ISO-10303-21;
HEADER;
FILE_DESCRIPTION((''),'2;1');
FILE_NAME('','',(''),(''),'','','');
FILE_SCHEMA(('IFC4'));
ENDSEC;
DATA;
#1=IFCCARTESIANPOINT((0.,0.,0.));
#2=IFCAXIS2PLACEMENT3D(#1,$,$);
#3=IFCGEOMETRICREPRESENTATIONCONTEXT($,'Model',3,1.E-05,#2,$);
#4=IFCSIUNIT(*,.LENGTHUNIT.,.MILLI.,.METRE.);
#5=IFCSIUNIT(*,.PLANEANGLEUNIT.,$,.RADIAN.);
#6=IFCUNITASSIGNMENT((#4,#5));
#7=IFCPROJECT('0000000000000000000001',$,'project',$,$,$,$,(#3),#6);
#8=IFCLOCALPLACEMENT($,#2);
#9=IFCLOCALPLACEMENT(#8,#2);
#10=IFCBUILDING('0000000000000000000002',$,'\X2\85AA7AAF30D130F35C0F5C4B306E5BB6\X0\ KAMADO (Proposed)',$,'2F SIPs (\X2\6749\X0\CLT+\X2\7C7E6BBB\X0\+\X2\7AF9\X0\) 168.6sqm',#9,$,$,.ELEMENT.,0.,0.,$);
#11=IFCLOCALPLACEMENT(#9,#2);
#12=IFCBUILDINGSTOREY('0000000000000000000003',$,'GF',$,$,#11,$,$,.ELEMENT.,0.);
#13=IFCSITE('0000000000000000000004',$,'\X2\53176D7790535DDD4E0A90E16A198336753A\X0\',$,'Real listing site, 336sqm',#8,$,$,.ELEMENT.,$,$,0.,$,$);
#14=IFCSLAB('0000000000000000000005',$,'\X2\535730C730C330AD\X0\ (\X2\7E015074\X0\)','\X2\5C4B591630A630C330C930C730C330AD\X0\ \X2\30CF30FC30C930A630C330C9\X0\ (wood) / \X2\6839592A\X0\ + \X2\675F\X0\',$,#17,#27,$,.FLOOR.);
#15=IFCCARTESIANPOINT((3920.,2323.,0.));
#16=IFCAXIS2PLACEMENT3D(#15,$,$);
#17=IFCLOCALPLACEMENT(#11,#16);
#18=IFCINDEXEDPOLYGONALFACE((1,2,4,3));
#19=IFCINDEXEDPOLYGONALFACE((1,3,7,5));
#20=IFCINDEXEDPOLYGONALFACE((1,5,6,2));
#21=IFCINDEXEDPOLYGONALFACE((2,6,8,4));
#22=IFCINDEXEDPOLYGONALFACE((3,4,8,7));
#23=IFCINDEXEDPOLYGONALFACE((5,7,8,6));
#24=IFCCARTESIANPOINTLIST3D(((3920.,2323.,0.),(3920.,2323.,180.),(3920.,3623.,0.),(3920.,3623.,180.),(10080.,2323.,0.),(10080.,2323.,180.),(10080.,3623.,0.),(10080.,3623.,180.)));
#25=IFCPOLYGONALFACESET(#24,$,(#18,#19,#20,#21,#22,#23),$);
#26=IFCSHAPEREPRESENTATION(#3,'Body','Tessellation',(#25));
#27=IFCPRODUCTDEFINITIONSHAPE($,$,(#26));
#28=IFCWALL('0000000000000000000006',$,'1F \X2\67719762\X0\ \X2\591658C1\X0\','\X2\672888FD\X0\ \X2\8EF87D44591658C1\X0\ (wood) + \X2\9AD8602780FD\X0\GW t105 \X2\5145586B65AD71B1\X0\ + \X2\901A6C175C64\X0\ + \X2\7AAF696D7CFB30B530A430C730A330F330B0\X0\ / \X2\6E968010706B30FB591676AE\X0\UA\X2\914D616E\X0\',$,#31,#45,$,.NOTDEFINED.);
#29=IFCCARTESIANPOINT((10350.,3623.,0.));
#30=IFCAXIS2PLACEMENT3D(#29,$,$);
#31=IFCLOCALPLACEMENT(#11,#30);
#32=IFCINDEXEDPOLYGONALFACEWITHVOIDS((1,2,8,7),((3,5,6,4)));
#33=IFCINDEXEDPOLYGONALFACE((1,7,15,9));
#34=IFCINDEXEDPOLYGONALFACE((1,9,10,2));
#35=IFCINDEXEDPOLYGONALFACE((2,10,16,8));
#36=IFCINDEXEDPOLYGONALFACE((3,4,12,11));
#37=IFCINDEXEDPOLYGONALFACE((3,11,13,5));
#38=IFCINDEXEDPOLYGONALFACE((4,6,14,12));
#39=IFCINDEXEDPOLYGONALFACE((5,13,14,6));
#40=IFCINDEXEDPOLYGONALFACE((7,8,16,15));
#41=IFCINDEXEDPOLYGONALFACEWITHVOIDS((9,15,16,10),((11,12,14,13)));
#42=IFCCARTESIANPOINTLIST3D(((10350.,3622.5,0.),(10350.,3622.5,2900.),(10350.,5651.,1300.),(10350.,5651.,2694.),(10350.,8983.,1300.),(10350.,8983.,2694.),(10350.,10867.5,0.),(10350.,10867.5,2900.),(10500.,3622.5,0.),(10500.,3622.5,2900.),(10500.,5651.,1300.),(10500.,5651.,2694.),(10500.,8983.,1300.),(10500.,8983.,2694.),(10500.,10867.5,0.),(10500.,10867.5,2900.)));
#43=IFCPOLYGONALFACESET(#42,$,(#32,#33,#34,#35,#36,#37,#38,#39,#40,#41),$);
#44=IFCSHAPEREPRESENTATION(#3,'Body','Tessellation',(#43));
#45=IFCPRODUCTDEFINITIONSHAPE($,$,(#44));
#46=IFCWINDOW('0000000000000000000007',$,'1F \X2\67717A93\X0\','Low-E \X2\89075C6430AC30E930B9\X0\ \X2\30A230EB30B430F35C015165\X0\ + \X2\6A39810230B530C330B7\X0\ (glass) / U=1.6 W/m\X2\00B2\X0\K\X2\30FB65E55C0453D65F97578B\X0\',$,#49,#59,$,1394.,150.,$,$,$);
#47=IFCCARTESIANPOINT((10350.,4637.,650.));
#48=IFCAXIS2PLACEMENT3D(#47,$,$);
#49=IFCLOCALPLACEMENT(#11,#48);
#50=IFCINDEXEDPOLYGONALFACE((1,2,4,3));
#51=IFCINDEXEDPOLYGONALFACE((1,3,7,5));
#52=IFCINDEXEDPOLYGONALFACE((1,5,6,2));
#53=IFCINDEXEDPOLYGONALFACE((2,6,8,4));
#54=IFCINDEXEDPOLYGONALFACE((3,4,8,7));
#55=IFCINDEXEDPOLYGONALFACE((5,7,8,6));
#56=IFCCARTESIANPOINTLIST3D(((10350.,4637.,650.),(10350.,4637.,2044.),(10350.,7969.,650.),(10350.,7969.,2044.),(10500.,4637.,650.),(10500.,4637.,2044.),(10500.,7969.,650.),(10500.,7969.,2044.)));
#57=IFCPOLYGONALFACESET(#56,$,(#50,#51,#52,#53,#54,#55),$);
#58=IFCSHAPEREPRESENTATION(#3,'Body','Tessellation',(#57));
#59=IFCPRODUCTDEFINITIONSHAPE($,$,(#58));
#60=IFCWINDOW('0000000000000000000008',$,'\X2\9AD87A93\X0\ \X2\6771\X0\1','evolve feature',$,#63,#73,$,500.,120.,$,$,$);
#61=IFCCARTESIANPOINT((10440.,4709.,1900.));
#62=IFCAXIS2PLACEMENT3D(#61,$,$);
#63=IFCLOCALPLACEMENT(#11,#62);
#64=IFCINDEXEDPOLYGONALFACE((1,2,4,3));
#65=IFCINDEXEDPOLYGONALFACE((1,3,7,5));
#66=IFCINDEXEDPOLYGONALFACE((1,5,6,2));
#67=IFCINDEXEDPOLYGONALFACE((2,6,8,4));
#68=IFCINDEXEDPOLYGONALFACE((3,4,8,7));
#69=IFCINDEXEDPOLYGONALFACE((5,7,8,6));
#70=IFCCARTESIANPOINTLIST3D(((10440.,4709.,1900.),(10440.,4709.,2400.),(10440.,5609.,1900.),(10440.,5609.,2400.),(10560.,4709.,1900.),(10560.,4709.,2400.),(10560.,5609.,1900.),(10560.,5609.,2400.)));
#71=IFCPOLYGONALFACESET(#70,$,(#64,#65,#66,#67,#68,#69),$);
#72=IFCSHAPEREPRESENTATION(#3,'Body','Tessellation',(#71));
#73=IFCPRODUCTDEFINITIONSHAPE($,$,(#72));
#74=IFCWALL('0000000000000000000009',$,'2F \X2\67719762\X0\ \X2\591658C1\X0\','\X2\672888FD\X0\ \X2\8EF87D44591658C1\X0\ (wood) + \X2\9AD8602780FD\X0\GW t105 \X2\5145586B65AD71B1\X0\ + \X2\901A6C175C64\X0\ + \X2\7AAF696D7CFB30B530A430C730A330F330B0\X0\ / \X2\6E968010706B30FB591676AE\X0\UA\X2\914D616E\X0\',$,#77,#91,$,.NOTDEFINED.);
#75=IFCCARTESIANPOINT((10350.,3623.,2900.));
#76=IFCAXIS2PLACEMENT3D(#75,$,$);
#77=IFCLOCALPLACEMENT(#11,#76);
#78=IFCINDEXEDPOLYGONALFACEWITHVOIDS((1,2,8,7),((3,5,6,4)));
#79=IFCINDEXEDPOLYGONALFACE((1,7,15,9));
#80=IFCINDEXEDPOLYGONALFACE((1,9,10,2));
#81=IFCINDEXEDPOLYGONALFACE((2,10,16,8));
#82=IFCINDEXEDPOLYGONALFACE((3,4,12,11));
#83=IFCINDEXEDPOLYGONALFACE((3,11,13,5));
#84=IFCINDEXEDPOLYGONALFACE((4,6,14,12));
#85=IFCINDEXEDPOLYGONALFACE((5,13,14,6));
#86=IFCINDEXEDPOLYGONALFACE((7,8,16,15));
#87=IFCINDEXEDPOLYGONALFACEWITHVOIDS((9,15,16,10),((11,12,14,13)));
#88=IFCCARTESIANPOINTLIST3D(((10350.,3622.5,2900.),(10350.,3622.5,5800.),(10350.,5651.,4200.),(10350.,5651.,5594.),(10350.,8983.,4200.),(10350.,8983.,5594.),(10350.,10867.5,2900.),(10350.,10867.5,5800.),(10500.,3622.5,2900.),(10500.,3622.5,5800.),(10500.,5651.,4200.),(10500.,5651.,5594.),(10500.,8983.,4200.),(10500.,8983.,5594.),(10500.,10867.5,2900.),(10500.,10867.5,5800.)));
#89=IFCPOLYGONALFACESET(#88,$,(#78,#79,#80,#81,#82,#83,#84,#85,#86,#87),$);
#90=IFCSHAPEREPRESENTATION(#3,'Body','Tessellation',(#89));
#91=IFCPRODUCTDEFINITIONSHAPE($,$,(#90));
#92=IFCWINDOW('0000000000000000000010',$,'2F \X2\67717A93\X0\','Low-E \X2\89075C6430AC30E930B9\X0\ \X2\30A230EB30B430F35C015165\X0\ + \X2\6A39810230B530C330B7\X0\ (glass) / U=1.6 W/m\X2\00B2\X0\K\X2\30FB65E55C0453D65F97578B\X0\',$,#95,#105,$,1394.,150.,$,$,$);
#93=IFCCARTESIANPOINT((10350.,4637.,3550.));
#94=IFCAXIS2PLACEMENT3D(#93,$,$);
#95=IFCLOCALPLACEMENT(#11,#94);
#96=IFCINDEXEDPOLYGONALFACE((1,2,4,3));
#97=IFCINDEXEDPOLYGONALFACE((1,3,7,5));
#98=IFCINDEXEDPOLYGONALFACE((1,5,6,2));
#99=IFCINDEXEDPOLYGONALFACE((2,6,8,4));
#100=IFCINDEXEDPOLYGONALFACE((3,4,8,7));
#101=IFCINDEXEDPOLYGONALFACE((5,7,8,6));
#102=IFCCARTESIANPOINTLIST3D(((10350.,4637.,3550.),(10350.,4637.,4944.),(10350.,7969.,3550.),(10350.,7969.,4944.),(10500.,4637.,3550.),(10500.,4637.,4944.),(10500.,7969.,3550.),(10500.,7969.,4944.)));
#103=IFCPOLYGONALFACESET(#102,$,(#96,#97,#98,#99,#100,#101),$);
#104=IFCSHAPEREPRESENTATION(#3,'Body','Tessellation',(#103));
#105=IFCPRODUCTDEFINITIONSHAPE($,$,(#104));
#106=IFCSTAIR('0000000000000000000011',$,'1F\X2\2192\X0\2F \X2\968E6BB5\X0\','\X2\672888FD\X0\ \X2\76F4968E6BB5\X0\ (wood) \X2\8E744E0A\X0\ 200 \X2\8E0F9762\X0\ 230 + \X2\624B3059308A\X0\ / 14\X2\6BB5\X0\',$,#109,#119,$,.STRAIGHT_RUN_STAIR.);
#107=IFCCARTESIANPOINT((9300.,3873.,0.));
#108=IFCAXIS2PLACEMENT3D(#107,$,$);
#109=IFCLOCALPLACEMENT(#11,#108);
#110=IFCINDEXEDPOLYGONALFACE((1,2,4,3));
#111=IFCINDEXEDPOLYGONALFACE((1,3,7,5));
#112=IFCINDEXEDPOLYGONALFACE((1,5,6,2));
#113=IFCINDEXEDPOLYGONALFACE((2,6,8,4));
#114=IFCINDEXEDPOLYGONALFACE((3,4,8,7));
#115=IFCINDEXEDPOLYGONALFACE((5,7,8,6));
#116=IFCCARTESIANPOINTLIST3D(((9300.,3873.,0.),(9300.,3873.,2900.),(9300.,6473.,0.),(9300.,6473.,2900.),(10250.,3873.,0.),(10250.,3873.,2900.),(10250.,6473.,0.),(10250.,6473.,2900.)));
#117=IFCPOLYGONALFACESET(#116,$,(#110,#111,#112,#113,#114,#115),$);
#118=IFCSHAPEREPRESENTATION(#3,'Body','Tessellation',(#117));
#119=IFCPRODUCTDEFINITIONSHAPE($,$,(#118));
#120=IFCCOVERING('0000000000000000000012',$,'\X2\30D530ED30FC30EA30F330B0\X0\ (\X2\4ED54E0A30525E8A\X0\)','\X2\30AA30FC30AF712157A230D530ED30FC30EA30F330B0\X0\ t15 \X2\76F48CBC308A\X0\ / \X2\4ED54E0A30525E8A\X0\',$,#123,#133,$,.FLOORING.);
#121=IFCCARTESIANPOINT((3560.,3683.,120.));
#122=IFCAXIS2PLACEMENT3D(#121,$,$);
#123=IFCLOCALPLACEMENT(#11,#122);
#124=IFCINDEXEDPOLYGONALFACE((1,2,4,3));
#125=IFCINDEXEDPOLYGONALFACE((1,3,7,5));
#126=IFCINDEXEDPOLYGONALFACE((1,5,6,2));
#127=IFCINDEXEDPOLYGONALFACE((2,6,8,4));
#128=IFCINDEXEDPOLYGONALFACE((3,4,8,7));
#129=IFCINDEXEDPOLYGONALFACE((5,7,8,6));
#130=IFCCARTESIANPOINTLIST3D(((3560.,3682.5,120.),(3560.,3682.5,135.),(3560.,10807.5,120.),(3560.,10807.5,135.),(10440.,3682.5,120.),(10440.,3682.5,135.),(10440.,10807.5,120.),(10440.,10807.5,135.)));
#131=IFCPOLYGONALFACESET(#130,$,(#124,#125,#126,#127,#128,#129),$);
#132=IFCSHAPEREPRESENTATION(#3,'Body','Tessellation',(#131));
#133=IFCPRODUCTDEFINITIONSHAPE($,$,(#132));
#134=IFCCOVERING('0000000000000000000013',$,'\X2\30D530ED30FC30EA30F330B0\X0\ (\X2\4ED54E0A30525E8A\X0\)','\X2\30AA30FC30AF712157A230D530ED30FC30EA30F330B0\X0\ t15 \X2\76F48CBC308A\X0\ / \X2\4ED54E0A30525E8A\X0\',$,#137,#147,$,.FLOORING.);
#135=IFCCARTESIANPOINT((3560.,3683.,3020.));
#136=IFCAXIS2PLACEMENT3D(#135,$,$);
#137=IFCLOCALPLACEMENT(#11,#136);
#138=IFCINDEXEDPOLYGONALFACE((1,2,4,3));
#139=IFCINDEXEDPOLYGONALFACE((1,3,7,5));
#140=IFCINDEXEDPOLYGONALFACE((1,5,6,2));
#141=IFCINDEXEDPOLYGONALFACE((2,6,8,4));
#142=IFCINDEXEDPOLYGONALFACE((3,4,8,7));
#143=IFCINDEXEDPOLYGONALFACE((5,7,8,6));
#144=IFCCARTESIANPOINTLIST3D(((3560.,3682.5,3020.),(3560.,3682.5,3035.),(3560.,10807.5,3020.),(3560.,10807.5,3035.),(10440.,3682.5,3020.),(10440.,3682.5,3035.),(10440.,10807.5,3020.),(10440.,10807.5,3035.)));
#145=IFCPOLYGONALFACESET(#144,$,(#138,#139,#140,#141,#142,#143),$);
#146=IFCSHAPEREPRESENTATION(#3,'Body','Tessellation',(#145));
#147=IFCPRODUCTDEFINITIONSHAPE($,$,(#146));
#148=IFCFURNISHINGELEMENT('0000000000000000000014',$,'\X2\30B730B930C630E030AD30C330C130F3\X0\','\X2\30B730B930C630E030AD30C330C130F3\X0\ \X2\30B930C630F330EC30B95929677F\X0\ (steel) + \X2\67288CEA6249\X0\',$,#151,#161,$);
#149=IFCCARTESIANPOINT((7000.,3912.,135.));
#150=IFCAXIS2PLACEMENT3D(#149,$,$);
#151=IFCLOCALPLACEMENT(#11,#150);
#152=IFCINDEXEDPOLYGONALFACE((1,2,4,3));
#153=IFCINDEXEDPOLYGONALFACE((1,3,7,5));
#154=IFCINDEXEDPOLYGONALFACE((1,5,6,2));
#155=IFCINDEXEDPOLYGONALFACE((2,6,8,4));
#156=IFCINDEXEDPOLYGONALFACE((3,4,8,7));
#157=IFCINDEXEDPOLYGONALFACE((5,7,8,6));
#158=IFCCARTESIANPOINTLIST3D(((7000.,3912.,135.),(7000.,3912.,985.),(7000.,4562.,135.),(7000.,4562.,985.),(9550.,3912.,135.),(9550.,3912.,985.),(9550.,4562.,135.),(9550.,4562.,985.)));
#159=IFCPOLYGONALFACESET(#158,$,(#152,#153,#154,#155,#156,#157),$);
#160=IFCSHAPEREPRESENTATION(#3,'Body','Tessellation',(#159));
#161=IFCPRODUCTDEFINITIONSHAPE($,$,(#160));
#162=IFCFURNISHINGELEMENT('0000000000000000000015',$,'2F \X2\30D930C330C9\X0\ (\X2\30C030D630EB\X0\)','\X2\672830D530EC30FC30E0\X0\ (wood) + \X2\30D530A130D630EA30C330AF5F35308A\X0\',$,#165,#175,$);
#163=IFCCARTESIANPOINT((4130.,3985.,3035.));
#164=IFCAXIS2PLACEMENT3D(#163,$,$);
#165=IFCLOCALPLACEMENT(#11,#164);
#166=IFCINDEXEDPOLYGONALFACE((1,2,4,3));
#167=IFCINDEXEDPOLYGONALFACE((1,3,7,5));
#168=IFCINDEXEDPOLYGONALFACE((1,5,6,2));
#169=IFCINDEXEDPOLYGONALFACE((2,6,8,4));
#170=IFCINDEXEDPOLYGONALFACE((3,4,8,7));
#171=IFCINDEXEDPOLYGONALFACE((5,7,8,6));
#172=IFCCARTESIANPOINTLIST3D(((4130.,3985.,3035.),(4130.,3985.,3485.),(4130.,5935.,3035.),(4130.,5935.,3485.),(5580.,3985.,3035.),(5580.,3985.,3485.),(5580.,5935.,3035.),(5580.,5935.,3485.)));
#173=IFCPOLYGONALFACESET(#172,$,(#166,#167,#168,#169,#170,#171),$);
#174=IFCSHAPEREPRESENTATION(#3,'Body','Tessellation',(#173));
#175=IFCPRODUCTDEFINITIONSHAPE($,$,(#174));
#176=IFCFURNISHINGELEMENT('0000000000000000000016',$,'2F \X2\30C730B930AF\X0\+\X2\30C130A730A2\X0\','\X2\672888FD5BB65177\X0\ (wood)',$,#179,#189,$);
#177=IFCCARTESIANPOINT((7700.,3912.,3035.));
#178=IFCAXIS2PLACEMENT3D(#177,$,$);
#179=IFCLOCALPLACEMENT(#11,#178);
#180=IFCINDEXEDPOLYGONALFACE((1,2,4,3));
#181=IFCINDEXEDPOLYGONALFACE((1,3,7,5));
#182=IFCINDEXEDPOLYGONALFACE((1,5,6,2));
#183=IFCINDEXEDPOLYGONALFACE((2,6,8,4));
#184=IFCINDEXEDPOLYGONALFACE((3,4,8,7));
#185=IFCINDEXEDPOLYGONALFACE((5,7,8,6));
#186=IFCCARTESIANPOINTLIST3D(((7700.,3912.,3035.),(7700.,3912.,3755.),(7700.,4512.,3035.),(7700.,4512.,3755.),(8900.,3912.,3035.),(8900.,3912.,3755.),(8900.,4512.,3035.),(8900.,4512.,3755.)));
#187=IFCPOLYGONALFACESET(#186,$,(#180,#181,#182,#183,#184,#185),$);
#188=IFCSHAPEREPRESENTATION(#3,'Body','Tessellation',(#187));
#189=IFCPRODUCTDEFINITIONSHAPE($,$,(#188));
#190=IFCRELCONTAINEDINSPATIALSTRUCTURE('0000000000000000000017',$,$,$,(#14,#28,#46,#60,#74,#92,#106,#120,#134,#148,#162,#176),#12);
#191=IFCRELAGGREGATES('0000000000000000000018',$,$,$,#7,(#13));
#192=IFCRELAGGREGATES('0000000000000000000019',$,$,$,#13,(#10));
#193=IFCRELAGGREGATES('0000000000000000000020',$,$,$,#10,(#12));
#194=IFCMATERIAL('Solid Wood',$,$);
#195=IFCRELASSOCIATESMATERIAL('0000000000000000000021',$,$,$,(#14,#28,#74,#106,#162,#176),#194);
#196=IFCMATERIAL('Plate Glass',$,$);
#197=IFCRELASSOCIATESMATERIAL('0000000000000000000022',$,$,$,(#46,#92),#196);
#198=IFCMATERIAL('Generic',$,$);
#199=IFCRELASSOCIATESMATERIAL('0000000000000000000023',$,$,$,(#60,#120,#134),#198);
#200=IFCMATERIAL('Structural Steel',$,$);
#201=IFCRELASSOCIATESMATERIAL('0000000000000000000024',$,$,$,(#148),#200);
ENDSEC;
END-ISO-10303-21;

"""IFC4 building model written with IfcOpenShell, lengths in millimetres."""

from ifc_helpers import new_model, si_unit, frame, frame_2d, origin, place, context, project, spatial, rectangle, extrude, material, element, fill, save


model = new_model("IFC4")

# Units and contexts
model_context = context("Model", 3, precision=1e-05, world=origin())
ifc_project = project(units=[si_unit("LENGTHUNIT", "METRE", prefix="MILLI"), si_unit("PLANEANGLEUNIT", "RADIAN")], contexts=[model_context])

# Site, building, storey
site_placement = place(None, origin())
site = spatial("IfcSite", under=ifc_project, at=site_placement, Name="北海道川上郡標茶町", ObjectType="Real listing site, 336sqm", CompositionType="ELEMENT", RefElevation=0.0)
building_placement = place(site_placement, origin())
building = spatial("IfcBuilding", under=site, at=building_placement, Name="薪窯パン小屋の家 KAMADO (Proposed)", ObjectType="2F SIPs (杉CLT+籾殻+竹) 168.6sqm", CompositionType="ELEMENT", ElevationOfRefHeight=0.0, ElevationOfTerrain=0.0)
storey_placement = place(building_placement, origin())
storey = spatial("IfcBuildingStorey", under=building, at=storey_placement, Name="GF", CompositionType="ELEMENT", Elevation=0.0)

# Slab
ifc_material_1 = material(Name="Solid Wood")
slab_placement = place(storey_placement, frame((3920.0, 2323.0, 0.0)))
element("IfcSlab", 1, at=slab_placement, inside=storey, material=ifc_material_1, Name="南デッキ (縁側)", Description="屋外ウッドデッキ ハードウッド (wood) / 根太 + 束", PredefinedType="FLOOR", context=model_context, shape_type="SweptSolid", body=[
    extrude(rectangle(XDim=6160.0, YDim=1300.0, at=frame_2d((3080.0, 650.0))), frame((3920.0, 2323.0, 0.0)), (0.0, 0.0, 1.0), 180.0),
])

# Wall, openings, windows
wall_1_placement = place(storey_placement, frame((10350.0, 3623.0, 0.0)))
wall_1 = element("IfcWall", 2, at=wall_1_placement, inside=storey, material=ifc_material_1, Name="1F 東面 外壁", Description="木製 軸組外壁 (wood) + 高性能GW t105 充填断熱 + 通気層 + 窯業系サイディング / 準耐火・外皮UA配慮", PredefinedType="NOTDEFINED", context=model_context, shape_type="SweptSolid", body=[
    extrude(rectangle(XDim=150.0, YDim=7245.0, at=frame_2d((75.0, 3622.0))), frame((10350.0, 3623.0, 0.0)), (0.0, 0.0, 1.0), 2900.0),
])
opening_1_placement = place(storey_placement, frame((10350.0, 4637.0, 650.0)))
opening_1 = element("IfcOpeningElement", 3, at=opening_1_placement, cuts=wall_1, PredefinedType="NOTDEFINED", context=model_context, shape_type="SweptSolid", body=[
    extrude(rectangle(XDim=150.0, YDim=3332.0, at=frame_2d((75.0, 1666.0))), frame((10350.0, 4637.0, 650.0)), (0.0, 0.0, 1.0), 1394.0),
])
opening_2_placement = place(storey_placement, frame((10440.0, 4709.0, 1900.0)))
opening_2 = element("IfcOpeningElement", 4, at=opening_2_placement, cuts=wall_1, PredefinedType="NOTDEFINED", context=model_context, shape_type="SweptSolid", body=[
    extrude(rectangle(XDim=120.0, YDim=900.0, at=frame_2d((60.0, 450.0))), frame((10440.0, 4709.0, 1900.0)), (0.0, 0.0, 1.0), 500.0),
])
ifc_material_2 = material(Name="Plate Glass")
window_1_placement = place(storey_placement, frame((10350.0, 4637.0, 650.0)))
window_1 = element("IfcWindow", 5, at=window_1_placement, inside=storey, material=ifc_material_2, Name="1F 東窓", Description="Low-E 複層ガラス アルゴン封入 + 樹脂サッシ (glass) / U=1.6 W/m²K・日射取得型", OverallHeight=1394.0, OverallWidth=150.0, context=model_context, shape_type="SweptSolid", body=[
    extrude(rectangle(XDim=150.0, YDim=3332.0, at=frame_2d((75.0, 1666.0))), frame((10350.0, 4637.0, 650.0)), (0.0, 0.0, 1.0), 1394.0),
])
fill(opening_1, window_1)
ifc_material_3 = material(Name="Generic")
window_2_placement = place(storey_placement, frame((10440.0, 4709.0, 1900.0)))
window_2 = element("IfcWindow", 6, at=window_2_placement, inside=storey, material=ifc_material_3, Name="高窓 東1", Description="evolve feature", OverallHeight=500.0, OverallWidth=120.0, context=model_context, shape_type="SweptSolid", body=[
    extrude(rectangle(XDim=120.0, YDim=900.0, at=frame_2d((60.0, 450.0))), frame((10440.0, 4709.0, 1900.0)), (0.0, 0.0, 1.0), 500.0),
])
fill(opening_2, window_2)

# Wall, opening, window
wall_2_placement = place(storey_placement, frame((10350.0, 3623.0, 2900.0)))
wall_2 = element("IfcWall", 7, at=wall_2_placement, inside=storey, material=ifc_material_1, Name="2F 東面 外壁", Description="木製 軸組外壁 (wood) + 高性能GW t105 充填断熱 + 通気層 + 窯業系サイディング / 準耐火・外皮UA配慮", PredefinedType="NOTDEFINED", context=model_context, shape_type="SweptSolid", body=[
    extrude(rectangle(XDim=150.0, YDim=7245.0, at=frame_2d((75.0, 3622.0))), frame((10350.0, 3623.0, 2900.0)), (0.0, 0.0, 1.0), 2900.0),
])
opening_3_placement = place(storey_placement, frame((10350.0, 4637.0, 3550.0)))
opening_3 = element("IfcOpeningElement", 8, at=opening_3_placement, cuts=wall_2, PredefinedType="NOTDEFINED", context=model_context, shape_type="SweptSolid", body=[
    extrude(rectangle(XDim=150.0, YDim=3332.0, at=frame_2d((75.0, 1666.0))), frame((10350.0, 4637.0, 3550.0)), (0.0, 0.0, 1.0), 1394.0),
])
window_3_placement = place(storey_placement, frame((10350.0, 4637.0, 3550.0)))
window_3 = element("IfcWindow", 9, at=window_3_placement, inside=storey, material=ifc_material_2, Name="2F 東窓", Description="Low-E 複層ガラス アルゴン封入 + 樹脂サッシ (glass) / U=1.6 W/m²K・日射取得型", OverallHeight=1394.0, OverallWidth=150.0, context=model_context, shape_type="SweptSolid", body=[
    extrude(rectangle(XDim=150.0, YDim=3332.0, at=frame_2d((75.0, 1666.0))), frame((10350.0, 4637.0, 3550.0)), (0.0, 0.0, 1.0), 1394.0),
])
fill(opening_3, window_3)

# Stair
stair_placement = place(storey_placement, frame((9300.0, 3873.0, 0.0)))
element("IfcStair", 10, at=stair_placement, inside=storey, material=ifc_material_1, Name="1F→2F 階段", Description="木製 直階段 (wood) 蹴上 200 踏面 230 + 手すり / 14段", PredefinedType="STRAIGHT_RUN_STAIR", context=model_context, shape_type="SweptSolid", body=[
    extrude(rectangle(XDim=950.0, YDim=2600.0, at=frame_2d((475.0, 1300.0))), frame((9300.0, 3873.0, 0.0)), (0.0, 0.0, 1.0), 2900.0),
])

# Coverings
covering_1_placement = place(storey_placement, frame((3560.0, 3683.0, 120.0)))
element("IfcCovering", 11, at=covering_1_placement, inside=storey, material=ifc_material_3, Name="フローリング (仕上げ床)", Description="オーク無垢フローリング t15 直貼り / 仕上げ床", PredefinedType="FLOORING", context=model_context, shape_type="SweptSolid", body=[
    extrude(rectangle(XDim=6880.0, YDim=7125.0, at=frame_2d((3440.0, 3562.0))), frame((3560.0, 3683.0, 120.0)), (0.0, 0.0, 1.0), 15.0),
])
covering_2_placement = place(storey_placement, frame((3560.0, 3683.0, 3020.0)))
element("IfcCovering", 12, at=covering_2_placement, inside=storey, material=ifc_material_3, Name="フローリング (仕上げ床)", Description="オーク無垢フローリング t15 直貼り / 仕上げ床", PredefinedType="FLOORING", context=model_context, shape_type="SweptSolid", body=[
    extrude(rectangle(XDim=6880.0, YDim=7125.0, at=frame_2d((3440.0, 3562.0))), frame((3560.0, 3683.0, 3020.0)), (0.0, 0.0, 1.0), 15.0),
])

# Furnishing elements
ifc_material_4 = material(Name="Structural Steel")
furnishing_1_placement = place(storey_placement, frame((7000.0, 3912.0, 135.0)))
element("IfcFurnishingElement", 13, at=furnishing_1_placement, inside=storey, material=ifc_material_4, Name="システムキッチン", Description="システムキッチン ステンレス天板 (steel) + 木質扉", context=model_context, shape_type="SweptSolid", body=[
    extrude(rectangle(XDim=2550.0, YDim=650.0, at=frame_2d((1275.0, 325.0))), frame((7000.0, 3912.0, 135.0)), (0.0, 0.0, 1.0), 850.0),
])
furnishing_2_placement = place(storey_placement, frame((4130.0, 3985.0, 3035.0)))
element("IfcFurnishingElement", 14, at=furnishing_2_placement, inside=storey, material=ifc_material_1, Name="2F ベッド (ダブル)", Description="木フレーム (wood) + ファブリック張り", context=model_context, shape_type="SweptSolid", body=[
    extrude(rectangle(XDim=1450.0, YDim=1950.0, at=frame_2d((725.0, 975.0))), frame((4130.0, 3985.0, 3035.0)), (0.0, 0.0, 1.0), 450.0),
])
furnishing_3_placement = place(storey_placement, frame((7700.0, 3912.0, 3035.0)))
element("IfcFurnishingElement", 15, at=furnishing_3_placement, inside=storey, material=ifc_material_1, Name="2F デスク+チェア", Description="木製家具 (wood)", context=model_context, shape_type="SweptSolid", body=[
    extrude(rectangle(XDim=1200.0, YDim=600.0, at=frame_2d((600.0, 300.0))), frame((7700.0, 3912.0, 3035.0)), (0.0, 0.0, 1.0), 720.0),
])

save(model, "model.ifc")
